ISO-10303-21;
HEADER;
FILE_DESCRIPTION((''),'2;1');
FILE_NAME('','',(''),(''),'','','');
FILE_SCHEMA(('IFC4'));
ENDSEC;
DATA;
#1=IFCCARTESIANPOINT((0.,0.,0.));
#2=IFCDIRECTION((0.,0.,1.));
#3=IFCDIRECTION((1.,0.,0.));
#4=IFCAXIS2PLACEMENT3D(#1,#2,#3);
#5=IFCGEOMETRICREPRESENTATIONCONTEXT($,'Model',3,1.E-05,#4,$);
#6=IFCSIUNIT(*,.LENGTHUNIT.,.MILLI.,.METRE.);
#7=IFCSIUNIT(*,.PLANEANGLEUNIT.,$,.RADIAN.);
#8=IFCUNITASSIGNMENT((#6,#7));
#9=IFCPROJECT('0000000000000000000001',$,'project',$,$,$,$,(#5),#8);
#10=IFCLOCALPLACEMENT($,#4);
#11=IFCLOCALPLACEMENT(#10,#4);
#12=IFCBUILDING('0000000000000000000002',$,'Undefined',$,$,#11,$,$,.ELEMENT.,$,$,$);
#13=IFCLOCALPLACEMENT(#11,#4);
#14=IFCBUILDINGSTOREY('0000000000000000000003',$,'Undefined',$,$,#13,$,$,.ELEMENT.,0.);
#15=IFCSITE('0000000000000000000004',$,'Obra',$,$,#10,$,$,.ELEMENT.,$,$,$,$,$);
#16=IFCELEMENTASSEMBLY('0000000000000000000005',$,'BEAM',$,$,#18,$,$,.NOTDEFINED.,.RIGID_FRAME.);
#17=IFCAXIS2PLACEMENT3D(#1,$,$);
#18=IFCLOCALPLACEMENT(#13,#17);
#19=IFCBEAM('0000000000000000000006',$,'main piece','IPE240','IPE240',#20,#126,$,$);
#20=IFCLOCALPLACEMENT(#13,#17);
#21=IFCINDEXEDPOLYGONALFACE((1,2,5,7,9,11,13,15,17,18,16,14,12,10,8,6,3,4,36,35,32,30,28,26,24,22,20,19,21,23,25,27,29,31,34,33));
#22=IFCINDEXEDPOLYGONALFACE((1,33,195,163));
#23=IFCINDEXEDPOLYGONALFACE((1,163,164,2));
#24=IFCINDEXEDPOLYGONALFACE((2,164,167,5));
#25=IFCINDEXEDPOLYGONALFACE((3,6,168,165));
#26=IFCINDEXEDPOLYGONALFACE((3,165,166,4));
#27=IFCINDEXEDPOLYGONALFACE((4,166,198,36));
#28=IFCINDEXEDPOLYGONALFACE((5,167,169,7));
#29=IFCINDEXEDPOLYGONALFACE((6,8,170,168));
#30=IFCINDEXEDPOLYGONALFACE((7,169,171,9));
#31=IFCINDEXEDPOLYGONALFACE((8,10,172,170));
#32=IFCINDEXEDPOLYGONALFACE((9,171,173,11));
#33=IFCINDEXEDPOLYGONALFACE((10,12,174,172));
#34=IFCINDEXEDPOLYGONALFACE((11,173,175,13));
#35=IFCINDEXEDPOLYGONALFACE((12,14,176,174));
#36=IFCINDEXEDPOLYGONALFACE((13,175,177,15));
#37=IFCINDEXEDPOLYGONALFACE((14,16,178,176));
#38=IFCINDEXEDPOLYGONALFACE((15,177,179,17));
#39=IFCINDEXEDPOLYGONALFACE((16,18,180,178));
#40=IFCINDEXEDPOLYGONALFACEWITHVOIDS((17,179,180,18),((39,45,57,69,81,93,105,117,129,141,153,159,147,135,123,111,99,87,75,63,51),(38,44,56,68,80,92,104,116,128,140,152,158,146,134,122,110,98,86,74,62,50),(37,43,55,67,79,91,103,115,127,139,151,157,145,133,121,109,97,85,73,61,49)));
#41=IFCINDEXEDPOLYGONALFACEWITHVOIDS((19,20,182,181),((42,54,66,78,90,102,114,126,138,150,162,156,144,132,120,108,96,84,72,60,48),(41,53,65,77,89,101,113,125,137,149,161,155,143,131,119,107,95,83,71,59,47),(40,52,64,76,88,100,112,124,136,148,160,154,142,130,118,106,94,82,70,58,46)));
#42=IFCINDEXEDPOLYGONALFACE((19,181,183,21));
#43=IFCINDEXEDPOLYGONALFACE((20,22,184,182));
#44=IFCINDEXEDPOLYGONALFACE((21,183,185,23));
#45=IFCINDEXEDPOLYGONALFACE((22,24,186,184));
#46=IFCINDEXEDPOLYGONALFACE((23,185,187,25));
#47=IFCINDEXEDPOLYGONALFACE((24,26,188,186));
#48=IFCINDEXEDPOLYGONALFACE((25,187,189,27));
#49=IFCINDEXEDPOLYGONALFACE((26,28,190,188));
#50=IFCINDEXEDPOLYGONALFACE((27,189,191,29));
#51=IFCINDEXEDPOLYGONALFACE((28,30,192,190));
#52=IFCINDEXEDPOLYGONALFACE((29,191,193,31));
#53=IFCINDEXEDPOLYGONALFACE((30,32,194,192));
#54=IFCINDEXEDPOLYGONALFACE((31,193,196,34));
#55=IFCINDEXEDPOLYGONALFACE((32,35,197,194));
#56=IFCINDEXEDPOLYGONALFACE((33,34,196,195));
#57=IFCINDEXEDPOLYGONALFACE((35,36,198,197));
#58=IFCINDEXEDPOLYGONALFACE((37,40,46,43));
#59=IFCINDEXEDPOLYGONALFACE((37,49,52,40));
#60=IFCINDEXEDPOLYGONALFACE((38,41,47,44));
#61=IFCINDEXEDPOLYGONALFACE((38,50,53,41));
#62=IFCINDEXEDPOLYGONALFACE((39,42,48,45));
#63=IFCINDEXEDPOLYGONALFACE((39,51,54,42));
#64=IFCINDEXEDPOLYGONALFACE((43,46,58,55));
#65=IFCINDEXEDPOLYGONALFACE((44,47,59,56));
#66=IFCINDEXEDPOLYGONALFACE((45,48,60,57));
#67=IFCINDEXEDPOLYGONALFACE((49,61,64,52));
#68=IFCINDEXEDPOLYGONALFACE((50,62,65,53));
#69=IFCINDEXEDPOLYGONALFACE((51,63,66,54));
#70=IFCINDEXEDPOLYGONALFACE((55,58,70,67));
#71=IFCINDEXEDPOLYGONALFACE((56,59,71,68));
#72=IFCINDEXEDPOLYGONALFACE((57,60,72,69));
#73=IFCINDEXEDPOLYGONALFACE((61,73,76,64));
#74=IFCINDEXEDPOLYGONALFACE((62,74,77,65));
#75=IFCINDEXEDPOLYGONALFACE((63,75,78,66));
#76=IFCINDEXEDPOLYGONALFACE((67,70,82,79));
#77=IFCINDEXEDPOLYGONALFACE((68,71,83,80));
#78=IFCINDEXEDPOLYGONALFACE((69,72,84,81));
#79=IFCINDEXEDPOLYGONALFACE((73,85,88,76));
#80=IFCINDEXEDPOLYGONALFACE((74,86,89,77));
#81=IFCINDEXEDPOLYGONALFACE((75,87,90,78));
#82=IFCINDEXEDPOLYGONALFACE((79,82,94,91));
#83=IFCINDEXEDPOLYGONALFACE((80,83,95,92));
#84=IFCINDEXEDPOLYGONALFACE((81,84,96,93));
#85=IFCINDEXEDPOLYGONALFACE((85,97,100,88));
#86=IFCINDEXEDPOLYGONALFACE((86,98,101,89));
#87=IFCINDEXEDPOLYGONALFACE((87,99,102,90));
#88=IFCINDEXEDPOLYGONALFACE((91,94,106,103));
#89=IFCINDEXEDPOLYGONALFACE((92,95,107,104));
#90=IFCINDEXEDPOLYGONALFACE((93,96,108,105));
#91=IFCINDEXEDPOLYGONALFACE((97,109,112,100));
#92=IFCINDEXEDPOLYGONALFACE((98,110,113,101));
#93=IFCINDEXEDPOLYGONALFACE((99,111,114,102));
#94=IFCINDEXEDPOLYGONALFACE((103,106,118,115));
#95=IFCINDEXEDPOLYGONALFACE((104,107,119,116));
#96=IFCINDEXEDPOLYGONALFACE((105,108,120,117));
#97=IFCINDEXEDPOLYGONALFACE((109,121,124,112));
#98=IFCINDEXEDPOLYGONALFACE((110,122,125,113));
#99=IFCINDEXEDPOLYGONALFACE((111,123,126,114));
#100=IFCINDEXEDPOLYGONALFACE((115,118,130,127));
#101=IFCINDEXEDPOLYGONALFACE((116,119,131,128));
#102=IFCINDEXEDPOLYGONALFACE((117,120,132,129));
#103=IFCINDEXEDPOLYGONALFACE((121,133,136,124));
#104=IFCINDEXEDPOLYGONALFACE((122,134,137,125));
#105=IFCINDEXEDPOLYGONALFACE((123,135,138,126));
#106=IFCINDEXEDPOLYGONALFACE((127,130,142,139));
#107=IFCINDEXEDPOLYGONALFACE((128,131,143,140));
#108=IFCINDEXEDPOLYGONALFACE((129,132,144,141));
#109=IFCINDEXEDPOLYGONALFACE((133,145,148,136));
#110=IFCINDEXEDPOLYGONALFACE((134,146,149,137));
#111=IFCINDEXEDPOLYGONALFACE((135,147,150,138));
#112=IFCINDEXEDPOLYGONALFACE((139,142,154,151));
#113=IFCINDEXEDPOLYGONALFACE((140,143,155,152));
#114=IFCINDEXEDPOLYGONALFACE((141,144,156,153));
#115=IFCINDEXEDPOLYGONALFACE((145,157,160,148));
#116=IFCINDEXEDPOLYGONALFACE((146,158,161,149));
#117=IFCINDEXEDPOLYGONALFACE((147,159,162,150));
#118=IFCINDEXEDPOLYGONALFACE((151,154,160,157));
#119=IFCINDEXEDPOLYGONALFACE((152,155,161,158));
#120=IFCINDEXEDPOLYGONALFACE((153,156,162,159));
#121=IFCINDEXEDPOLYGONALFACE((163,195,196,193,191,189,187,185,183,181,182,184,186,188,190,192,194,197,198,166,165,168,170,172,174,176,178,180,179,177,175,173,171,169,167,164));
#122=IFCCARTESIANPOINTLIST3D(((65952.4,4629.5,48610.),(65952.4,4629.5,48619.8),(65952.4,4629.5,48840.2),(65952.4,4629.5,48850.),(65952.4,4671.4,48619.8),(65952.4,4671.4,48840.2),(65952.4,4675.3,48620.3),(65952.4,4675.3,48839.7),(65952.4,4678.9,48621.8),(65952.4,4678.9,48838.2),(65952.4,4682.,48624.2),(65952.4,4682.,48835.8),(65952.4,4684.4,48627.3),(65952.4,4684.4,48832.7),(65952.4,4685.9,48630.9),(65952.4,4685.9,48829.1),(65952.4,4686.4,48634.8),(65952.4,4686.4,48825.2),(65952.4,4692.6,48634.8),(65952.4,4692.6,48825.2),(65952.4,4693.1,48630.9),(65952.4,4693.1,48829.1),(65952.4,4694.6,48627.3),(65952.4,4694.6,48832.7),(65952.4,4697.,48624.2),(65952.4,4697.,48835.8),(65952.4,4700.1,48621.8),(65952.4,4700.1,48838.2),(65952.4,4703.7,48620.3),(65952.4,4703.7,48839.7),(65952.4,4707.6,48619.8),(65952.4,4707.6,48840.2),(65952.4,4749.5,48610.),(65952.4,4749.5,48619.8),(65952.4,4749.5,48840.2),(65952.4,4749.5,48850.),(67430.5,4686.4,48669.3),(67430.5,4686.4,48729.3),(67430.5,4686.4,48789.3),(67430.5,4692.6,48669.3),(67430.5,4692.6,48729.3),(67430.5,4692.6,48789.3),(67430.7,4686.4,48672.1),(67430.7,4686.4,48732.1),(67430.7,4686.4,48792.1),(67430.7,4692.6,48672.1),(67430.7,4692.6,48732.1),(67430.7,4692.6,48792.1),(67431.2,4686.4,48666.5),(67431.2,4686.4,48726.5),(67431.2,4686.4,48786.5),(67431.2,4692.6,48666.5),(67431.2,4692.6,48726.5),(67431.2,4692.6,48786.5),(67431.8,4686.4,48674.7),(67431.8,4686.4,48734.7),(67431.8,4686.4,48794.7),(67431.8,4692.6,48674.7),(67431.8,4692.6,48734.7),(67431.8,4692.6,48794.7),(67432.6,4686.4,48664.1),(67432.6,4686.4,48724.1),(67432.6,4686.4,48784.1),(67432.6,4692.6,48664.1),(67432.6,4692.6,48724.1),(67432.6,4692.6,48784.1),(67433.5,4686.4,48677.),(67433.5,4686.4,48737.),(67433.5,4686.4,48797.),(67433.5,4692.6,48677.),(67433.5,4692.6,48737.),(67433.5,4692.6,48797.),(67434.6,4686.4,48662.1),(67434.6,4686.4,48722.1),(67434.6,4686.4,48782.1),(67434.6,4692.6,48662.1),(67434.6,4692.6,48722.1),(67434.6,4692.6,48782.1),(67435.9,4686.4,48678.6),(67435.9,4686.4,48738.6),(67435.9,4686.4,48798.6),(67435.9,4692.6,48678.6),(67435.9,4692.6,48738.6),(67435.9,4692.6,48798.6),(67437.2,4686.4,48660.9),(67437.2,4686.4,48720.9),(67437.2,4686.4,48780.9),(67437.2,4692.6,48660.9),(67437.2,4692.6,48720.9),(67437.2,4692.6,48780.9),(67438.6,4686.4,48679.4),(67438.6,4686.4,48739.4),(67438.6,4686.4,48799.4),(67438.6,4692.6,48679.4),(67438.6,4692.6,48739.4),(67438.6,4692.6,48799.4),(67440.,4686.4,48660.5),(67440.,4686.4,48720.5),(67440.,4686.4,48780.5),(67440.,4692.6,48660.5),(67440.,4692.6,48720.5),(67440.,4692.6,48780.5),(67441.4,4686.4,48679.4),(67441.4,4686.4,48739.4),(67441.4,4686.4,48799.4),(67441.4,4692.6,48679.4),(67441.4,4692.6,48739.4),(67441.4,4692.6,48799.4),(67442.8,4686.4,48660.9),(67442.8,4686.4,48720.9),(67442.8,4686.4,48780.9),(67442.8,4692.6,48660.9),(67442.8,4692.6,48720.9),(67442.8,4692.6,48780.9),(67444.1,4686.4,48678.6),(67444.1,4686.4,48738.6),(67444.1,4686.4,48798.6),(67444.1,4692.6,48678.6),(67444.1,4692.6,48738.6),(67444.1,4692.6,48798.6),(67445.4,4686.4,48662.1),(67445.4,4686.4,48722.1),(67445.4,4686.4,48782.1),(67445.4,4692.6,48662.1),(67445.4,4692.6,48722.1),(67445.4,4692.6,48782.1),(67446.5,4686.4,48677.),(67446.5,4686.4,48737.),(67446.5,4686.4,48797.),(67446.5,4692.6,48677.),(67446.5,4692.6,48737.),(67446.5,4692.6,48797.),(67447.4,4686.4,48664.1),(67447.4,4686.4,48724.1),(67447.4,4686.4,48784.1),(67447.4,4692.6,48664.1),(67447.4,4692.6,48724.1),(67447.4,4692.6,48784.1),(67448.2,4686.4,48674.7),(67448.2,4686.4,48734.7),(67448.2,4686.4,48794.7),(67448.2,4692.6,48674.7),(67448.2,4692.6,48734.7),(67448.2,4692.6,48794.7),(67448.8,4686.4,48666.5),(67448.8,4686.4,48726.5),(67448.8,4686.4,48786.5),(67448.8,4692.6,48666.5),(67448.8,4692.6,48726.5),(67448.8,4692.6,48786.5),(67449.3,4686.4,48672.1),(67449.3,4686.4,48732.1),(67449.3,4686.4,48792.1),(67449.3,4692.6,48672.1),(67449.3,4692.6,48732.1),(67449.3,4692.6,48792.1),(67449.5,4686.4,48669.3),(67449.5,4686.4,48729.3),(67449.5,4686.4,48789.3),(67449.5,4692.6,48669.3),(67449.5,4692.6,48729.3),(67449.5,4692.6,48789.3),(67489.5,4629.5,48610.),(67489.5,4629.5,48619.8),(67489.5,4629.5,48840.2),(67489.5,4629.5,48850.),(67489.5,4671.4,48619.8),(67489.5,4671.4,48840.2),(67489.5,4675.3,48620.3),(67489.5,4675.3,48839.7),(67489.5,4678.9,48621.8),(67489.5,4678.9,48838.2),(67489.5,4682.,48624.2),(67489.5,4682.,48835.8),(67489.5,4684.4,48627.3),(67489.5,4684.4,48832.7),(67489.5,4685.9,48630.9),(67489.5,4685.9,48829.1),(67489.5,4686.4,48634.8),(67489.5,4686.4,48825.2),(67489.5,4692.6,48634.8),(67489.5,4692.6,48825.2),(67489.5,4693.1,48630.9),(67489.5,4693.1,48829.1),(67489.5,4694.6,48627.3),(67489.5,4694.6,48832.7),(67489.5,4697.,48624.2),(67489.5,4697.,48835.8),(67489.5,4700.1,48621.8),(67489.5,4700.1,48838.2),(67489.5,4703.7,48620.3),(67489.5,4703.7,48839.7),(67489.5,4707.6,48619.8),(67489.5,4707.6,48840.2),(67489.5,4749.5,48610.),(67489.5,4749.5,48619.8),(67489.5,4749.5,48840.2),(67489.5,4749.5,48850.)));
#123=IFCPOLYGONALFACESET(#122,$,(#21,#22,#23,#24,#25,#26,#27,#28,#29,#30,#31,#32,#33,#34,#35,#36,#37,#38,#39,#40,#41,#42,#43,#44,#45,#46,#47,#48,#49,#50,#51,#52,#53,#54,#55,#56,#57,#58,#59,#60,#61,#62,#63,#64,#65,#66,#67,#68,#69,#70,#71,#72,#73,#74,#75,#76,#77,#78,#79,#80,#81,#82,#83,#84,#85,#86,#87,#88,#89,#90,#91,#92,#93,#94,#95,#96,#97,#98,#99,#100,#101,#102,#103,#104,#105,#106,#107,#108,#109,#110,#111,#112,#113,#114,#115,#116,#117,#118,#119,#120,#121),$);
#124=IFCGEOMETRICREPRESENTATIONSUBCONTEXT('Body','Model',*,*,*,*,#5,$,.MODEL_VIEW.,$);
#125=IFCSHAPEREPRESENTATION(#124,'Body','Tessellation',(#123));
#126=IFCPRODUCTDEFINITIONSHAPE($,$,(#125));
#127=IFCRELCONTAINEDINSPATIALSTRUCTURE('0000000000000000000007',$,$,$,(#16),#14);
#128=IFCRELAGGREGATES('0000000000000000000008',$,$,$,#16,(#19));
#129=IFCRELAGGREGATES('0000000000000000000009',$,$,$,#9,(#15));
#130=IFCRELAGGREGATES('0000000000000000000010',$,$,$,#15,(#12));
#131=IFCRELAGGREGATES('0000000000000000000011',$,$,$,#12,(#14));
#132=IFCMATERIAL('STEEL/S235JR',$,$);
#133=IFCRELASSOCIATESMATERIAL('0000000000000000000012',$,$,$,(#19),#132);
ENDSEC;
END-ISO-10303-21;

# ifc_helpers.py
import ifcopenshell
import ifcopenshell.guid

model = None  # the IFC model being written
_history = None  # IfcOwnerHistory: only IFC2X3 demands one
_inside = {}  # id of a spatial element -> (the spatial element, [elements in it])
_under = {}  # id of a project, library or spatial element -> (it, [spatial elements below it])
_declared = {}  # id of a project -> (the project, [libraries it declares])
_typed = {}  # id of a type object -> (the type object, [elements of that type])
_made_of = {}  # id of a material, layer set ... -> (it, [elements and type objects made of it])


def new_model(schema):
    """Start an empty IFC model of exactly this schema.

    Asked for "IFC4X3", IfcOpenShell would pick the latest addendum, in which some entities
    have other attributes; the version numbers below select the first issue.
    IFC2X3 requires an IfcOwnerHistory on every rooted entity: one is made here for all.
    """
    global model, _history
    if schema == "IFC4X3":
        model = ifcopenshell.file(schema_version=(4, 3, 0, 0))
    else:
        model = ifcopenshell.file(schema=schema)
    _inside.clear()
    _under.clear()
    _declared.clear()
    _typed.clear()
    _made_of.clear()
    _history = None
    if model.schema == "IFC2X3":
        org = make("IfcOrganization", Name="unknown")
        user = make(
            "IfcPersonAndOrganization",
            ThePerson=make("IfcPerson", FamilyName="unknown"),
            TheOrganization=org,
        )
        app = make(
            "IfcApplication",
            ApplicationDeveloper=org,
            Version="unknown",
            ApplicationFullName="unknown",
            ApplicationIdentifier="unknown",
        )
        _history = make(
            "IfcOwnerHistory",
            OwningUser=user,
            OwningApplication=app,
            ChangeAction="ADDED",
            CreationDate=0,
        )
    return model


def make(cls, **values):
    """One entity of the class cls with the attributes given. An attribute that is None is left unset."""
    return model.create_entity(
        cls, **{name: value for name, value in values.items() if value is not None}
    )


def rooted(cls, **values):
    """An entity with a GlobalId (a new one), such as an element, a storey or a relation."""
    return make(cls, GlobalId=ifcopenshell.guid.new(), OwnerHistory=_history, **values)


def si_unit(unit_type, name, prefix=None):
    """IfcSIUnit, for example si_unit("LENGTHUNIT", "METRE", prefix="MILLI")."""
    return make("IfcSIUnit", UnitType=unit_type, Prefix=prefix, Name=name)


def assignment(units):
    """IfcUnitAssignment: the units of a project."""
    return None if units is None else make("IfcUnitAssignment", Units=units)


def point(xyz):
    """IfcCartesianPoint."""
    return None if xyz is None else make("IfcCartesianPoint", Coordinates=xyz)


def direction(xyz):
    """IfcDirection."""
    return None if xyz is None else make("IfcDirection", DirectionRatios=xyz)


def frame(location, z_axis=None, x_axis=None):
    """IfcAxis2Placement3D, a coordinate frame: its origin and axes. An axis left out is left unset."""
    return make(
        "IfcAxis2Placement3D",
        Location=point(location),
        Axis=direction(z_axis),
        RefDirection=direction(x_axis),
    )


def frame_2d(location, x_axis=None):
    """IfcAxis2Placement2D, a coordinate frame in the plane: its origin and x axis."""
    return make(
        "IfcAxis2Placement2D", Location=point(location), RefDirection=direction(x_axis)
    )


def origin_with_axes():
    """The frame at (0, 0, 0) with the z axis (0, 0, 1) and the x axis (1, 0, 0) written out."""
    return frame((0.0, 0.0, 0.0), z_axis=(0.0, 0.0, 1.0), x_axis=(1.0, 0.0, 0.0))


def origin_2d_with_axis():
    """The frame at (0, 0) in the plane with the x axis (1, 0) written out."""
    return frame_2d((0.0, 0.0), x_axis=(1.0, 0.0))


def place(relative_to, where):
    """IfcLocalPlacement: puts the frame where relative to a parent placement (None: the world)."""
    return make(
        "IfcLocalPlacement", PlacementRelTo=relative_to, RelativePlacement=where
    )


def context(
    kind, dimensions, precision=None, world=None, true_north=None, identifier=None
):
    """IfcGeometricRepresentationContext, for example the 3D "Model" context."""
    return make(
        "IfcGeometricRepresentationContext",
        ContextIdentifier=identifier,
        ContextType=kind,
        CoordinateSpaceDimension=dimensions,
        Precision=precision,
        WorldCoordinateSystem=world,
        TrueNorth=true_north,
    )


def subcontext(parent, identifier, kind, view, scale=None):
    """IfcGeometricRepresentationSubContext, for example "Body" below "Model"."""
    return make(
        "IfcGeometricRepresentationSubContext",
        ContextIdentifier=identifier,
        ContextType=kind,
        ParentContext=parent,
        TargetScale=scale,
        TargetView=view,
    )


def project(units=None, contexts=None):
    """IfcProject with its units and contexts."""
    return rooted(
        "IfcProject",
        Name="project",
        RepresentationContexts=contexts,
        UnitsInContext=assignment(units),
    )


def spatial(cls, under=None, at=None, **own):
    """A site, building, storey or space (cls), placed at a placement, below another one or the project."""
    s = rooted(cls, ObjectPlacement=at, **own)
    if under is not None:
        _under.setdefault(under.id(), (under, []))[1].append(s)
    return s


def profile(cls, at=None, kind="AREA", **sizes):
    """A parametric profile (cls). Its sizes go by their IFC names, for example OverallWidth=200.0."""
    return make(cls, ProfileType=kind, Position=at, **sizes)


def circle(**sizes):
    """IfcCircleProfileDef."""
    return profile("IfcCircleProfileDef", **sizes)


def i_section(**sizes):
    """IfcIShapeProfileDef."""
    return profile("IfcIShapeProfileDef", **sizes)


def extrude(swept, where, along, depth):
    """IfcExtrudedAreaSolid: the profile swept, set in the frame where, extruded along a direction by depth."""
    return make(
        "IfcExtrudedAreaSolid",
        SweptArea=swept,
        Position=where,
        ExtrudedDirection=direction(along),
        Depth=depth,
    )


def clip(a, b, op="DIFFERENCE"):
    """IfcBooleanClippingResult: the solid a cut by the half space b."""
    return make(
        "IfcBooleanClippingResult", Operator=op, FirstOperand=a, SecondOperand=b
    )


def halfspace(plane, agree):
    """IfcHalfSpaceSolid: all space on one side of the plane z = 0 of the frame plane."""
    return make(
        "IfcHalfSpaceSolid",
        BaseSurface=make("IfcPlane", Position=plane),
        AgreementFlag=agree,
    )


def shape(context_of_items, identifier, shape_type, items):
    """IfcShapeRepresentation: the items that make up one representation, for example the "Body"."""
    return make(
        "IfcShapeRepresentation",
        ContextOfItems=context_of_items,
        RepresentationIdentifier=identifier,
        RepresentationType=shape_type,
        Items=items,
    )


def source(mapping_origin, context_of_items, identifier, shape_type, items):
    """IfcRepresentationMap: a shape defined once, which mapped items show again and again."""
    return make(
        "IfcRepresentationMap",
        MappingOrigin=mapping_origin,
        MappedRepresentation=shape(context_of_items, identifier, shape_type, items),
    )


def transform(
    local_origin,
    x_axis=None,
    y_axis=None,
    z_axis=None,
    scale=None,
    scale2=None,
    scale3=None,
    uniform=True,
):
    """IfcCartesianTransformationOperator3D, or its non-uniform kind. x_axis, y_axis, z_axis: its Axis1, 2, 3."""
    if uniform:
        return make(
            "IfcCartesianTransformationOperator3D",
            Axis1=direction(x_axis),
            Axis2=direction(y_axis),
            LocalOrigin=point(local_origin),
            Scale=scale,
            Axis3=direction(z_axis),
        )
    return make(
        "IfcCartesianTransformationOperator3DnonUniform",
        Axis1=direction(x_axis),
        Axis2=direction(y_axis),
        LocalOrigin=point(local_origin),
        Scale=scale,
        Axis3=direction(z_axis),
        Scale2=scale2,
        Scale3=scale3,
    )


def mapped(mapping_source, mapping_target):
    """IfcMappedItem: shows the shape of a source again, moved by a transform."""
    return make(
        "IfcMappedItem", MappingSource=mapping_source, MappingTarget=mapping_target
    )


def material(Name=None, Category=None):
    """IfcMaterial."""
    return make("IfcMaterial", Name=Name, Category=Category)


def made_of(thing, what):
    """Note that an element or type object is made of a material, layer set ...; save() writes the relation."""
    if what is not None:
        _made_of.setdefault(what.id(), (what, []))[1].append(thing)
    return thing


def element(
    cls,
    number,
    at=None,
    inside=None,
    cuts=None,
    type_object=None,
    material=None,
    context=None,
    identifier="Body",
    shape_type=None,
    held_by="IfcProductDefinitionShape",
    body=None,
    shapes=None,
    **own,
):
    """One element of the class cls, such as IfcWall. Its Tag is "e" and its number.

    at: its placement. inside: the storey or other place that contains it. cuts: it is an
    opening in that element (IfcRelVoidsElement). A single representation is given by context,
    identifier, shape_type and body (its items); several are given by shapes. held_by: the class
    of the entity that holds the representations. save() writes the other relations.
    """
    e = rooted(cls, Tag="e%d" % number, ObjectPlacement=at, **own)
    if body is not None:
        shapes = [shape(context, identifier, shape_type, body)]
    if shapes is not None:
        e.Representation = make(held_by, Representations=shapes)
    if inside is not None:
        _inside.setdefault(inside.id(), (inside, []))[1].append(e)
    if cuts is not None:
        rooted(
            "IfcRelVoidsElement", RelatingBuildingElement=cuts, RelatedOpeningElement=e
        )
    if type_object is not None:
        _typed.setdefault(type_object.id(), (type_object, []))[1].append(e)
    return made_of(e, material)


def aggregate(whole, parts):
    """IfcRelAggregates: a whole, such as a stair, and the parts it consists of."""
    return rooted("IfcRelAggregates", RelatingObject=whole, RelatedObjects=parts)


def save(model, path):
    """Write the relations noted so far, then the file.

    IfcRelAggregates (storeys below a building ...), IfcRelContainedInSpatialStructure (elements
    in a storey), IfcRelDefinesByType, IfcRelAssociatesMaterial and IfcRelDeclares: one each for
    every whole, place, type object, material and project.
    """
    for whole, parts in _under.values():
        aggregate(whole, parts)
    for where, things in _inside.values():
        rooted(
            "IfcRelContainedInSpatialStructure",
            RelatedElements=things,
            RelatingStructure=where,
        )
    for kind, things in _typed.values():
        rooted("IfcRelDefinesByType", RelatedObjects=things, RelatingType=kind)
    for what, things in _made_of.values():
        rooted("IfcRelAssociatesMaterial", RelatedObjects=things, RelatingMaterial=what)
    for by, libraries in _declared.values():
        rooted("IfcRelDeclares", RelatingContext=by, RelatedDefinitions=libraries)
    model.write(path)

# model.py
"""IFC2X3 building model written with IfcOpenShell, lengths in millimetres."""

from ifc_helpers import new_model, si_unit, frame, origin_with_axes, origin_2d_with_axis, place, context, subcontext, project, spatial, circle, i_section, extrude, clip, halfspace, source, transform, mapped, material, element, aggregate, save


model = new_model("IFC2X3")

# Units and contexts
model_context = context("Model", 3, precision=1e-05, world=origin_with_axes())
body_context = subcontext(model_context, "Body", "Model", "MODEL_VIEW")
ifc_project = project(units=[si_unit("LENGTHUNIT", "METRE", prefix="MILLI"), si_unit("PLANEANGLEUNIT", "RADIAN")], contexts=[model_context])

# Site, building, storey
site_placement = place(None, origin_with_axes())
site = spatial("IfcSite", under=ifc_project, at=site_placement, Name="Obra", CompositionType="ELEMENT")
building_placement = place(site_placement, origin_with_axes())
building = spatial("IfcBuilding", under=site, at=building_placement, Name="Undefined", CompositionType="ELEMENT")
storey_placement = place(building_placement, origin_with_axes())
storey = spatial("IfcBuildingStorey", under=building, at=storey_placement, Name="Undefined", CompositionType="ELEMENT", Elevation=0.0)

# Shared definitions
ifc_material_1 = material(Name="STEEL/S235JR")

# Element assembly, beam, opening
assembly_1_placement = place(storey_placement, origin_with_axes())
assembly_1 = element("IfcElementAssembly", 1, at=assembly_1_placement, inside=storey, Name="BEAM", AssemblyPlace="NOTDEFINED", PredefinedType="RIGID_FRAME")
beam_1_placement = place(assembly_1_placement, frame((65952.4, 4689.5, 48730.0), z_axis=(0.0, 0.0, 1.0), x_axis=(1.0, 0.0, 0.0)))
beam_1 = element("IfcBeam", 2, at=beam_1_placement, material=ifc_material_1, Name="main piece", Description="IPE240", ObjectType="IPE240", context=body_context, shape_type="Clipping", body=[
    clip(extrude(i_section(OverallWidth=120.0, OverallDepth=240.0, WebThickness=6.2, FlangeThickness=9.8, FilletRadius=15.0, at=origin_2d_with_axis()), frame((1754.5, 0.0, 0.0), z_axis=(-1.0, 0.0, 0.0), x_axis=(0.0, -1.0, 0.0)), (0.0, 0.0, 1.0), 1754.5), halfspace(frame((1537.1, -60.0, -120.0), z_axis=(1.0, 0.000019, 0.0), x_axis=(0.0, 0.0, 1.0)), False)),
])
shared_shape_1 = source(origin_with_axes(), body_context, "Body", "SweptSolid", [
    extrude(circle(Radius=9.5, at=origin_2d_with_axis()), frame((0.0, -3.2, 0.0), z_axis=(0.0, 1.0, 0.0), x_axis=(1.0, 0.0, 0.0)), (0.0, 0.0, 1.0), 6.4),
])
opening_1_placement = place(assembly_1_placement, frame((67490.0, 4689.5, 48850.0), z_axis=(-1.0, 0.0, 0.0), x_axis=(0.0, 0.0, -1.0)))
element("IfcOpeningElement", 3, at=opening_1_placement, cuts=beam_1, ObjectType="Opening", context=body_context, shape_type="MappedRepresentation", body=[
    mapped(shared_shape_1, transform((60.0, 0.0, 50.0))),
    mapped(shared_shape_1, transform((120.0, 0.0, 50.0))),
    mapped(shared_shape_1, transform((180.0, 0.0, 50.0))),
])
aggregate(assembly_1, [beam_1])

save(model, "model.ifc")
